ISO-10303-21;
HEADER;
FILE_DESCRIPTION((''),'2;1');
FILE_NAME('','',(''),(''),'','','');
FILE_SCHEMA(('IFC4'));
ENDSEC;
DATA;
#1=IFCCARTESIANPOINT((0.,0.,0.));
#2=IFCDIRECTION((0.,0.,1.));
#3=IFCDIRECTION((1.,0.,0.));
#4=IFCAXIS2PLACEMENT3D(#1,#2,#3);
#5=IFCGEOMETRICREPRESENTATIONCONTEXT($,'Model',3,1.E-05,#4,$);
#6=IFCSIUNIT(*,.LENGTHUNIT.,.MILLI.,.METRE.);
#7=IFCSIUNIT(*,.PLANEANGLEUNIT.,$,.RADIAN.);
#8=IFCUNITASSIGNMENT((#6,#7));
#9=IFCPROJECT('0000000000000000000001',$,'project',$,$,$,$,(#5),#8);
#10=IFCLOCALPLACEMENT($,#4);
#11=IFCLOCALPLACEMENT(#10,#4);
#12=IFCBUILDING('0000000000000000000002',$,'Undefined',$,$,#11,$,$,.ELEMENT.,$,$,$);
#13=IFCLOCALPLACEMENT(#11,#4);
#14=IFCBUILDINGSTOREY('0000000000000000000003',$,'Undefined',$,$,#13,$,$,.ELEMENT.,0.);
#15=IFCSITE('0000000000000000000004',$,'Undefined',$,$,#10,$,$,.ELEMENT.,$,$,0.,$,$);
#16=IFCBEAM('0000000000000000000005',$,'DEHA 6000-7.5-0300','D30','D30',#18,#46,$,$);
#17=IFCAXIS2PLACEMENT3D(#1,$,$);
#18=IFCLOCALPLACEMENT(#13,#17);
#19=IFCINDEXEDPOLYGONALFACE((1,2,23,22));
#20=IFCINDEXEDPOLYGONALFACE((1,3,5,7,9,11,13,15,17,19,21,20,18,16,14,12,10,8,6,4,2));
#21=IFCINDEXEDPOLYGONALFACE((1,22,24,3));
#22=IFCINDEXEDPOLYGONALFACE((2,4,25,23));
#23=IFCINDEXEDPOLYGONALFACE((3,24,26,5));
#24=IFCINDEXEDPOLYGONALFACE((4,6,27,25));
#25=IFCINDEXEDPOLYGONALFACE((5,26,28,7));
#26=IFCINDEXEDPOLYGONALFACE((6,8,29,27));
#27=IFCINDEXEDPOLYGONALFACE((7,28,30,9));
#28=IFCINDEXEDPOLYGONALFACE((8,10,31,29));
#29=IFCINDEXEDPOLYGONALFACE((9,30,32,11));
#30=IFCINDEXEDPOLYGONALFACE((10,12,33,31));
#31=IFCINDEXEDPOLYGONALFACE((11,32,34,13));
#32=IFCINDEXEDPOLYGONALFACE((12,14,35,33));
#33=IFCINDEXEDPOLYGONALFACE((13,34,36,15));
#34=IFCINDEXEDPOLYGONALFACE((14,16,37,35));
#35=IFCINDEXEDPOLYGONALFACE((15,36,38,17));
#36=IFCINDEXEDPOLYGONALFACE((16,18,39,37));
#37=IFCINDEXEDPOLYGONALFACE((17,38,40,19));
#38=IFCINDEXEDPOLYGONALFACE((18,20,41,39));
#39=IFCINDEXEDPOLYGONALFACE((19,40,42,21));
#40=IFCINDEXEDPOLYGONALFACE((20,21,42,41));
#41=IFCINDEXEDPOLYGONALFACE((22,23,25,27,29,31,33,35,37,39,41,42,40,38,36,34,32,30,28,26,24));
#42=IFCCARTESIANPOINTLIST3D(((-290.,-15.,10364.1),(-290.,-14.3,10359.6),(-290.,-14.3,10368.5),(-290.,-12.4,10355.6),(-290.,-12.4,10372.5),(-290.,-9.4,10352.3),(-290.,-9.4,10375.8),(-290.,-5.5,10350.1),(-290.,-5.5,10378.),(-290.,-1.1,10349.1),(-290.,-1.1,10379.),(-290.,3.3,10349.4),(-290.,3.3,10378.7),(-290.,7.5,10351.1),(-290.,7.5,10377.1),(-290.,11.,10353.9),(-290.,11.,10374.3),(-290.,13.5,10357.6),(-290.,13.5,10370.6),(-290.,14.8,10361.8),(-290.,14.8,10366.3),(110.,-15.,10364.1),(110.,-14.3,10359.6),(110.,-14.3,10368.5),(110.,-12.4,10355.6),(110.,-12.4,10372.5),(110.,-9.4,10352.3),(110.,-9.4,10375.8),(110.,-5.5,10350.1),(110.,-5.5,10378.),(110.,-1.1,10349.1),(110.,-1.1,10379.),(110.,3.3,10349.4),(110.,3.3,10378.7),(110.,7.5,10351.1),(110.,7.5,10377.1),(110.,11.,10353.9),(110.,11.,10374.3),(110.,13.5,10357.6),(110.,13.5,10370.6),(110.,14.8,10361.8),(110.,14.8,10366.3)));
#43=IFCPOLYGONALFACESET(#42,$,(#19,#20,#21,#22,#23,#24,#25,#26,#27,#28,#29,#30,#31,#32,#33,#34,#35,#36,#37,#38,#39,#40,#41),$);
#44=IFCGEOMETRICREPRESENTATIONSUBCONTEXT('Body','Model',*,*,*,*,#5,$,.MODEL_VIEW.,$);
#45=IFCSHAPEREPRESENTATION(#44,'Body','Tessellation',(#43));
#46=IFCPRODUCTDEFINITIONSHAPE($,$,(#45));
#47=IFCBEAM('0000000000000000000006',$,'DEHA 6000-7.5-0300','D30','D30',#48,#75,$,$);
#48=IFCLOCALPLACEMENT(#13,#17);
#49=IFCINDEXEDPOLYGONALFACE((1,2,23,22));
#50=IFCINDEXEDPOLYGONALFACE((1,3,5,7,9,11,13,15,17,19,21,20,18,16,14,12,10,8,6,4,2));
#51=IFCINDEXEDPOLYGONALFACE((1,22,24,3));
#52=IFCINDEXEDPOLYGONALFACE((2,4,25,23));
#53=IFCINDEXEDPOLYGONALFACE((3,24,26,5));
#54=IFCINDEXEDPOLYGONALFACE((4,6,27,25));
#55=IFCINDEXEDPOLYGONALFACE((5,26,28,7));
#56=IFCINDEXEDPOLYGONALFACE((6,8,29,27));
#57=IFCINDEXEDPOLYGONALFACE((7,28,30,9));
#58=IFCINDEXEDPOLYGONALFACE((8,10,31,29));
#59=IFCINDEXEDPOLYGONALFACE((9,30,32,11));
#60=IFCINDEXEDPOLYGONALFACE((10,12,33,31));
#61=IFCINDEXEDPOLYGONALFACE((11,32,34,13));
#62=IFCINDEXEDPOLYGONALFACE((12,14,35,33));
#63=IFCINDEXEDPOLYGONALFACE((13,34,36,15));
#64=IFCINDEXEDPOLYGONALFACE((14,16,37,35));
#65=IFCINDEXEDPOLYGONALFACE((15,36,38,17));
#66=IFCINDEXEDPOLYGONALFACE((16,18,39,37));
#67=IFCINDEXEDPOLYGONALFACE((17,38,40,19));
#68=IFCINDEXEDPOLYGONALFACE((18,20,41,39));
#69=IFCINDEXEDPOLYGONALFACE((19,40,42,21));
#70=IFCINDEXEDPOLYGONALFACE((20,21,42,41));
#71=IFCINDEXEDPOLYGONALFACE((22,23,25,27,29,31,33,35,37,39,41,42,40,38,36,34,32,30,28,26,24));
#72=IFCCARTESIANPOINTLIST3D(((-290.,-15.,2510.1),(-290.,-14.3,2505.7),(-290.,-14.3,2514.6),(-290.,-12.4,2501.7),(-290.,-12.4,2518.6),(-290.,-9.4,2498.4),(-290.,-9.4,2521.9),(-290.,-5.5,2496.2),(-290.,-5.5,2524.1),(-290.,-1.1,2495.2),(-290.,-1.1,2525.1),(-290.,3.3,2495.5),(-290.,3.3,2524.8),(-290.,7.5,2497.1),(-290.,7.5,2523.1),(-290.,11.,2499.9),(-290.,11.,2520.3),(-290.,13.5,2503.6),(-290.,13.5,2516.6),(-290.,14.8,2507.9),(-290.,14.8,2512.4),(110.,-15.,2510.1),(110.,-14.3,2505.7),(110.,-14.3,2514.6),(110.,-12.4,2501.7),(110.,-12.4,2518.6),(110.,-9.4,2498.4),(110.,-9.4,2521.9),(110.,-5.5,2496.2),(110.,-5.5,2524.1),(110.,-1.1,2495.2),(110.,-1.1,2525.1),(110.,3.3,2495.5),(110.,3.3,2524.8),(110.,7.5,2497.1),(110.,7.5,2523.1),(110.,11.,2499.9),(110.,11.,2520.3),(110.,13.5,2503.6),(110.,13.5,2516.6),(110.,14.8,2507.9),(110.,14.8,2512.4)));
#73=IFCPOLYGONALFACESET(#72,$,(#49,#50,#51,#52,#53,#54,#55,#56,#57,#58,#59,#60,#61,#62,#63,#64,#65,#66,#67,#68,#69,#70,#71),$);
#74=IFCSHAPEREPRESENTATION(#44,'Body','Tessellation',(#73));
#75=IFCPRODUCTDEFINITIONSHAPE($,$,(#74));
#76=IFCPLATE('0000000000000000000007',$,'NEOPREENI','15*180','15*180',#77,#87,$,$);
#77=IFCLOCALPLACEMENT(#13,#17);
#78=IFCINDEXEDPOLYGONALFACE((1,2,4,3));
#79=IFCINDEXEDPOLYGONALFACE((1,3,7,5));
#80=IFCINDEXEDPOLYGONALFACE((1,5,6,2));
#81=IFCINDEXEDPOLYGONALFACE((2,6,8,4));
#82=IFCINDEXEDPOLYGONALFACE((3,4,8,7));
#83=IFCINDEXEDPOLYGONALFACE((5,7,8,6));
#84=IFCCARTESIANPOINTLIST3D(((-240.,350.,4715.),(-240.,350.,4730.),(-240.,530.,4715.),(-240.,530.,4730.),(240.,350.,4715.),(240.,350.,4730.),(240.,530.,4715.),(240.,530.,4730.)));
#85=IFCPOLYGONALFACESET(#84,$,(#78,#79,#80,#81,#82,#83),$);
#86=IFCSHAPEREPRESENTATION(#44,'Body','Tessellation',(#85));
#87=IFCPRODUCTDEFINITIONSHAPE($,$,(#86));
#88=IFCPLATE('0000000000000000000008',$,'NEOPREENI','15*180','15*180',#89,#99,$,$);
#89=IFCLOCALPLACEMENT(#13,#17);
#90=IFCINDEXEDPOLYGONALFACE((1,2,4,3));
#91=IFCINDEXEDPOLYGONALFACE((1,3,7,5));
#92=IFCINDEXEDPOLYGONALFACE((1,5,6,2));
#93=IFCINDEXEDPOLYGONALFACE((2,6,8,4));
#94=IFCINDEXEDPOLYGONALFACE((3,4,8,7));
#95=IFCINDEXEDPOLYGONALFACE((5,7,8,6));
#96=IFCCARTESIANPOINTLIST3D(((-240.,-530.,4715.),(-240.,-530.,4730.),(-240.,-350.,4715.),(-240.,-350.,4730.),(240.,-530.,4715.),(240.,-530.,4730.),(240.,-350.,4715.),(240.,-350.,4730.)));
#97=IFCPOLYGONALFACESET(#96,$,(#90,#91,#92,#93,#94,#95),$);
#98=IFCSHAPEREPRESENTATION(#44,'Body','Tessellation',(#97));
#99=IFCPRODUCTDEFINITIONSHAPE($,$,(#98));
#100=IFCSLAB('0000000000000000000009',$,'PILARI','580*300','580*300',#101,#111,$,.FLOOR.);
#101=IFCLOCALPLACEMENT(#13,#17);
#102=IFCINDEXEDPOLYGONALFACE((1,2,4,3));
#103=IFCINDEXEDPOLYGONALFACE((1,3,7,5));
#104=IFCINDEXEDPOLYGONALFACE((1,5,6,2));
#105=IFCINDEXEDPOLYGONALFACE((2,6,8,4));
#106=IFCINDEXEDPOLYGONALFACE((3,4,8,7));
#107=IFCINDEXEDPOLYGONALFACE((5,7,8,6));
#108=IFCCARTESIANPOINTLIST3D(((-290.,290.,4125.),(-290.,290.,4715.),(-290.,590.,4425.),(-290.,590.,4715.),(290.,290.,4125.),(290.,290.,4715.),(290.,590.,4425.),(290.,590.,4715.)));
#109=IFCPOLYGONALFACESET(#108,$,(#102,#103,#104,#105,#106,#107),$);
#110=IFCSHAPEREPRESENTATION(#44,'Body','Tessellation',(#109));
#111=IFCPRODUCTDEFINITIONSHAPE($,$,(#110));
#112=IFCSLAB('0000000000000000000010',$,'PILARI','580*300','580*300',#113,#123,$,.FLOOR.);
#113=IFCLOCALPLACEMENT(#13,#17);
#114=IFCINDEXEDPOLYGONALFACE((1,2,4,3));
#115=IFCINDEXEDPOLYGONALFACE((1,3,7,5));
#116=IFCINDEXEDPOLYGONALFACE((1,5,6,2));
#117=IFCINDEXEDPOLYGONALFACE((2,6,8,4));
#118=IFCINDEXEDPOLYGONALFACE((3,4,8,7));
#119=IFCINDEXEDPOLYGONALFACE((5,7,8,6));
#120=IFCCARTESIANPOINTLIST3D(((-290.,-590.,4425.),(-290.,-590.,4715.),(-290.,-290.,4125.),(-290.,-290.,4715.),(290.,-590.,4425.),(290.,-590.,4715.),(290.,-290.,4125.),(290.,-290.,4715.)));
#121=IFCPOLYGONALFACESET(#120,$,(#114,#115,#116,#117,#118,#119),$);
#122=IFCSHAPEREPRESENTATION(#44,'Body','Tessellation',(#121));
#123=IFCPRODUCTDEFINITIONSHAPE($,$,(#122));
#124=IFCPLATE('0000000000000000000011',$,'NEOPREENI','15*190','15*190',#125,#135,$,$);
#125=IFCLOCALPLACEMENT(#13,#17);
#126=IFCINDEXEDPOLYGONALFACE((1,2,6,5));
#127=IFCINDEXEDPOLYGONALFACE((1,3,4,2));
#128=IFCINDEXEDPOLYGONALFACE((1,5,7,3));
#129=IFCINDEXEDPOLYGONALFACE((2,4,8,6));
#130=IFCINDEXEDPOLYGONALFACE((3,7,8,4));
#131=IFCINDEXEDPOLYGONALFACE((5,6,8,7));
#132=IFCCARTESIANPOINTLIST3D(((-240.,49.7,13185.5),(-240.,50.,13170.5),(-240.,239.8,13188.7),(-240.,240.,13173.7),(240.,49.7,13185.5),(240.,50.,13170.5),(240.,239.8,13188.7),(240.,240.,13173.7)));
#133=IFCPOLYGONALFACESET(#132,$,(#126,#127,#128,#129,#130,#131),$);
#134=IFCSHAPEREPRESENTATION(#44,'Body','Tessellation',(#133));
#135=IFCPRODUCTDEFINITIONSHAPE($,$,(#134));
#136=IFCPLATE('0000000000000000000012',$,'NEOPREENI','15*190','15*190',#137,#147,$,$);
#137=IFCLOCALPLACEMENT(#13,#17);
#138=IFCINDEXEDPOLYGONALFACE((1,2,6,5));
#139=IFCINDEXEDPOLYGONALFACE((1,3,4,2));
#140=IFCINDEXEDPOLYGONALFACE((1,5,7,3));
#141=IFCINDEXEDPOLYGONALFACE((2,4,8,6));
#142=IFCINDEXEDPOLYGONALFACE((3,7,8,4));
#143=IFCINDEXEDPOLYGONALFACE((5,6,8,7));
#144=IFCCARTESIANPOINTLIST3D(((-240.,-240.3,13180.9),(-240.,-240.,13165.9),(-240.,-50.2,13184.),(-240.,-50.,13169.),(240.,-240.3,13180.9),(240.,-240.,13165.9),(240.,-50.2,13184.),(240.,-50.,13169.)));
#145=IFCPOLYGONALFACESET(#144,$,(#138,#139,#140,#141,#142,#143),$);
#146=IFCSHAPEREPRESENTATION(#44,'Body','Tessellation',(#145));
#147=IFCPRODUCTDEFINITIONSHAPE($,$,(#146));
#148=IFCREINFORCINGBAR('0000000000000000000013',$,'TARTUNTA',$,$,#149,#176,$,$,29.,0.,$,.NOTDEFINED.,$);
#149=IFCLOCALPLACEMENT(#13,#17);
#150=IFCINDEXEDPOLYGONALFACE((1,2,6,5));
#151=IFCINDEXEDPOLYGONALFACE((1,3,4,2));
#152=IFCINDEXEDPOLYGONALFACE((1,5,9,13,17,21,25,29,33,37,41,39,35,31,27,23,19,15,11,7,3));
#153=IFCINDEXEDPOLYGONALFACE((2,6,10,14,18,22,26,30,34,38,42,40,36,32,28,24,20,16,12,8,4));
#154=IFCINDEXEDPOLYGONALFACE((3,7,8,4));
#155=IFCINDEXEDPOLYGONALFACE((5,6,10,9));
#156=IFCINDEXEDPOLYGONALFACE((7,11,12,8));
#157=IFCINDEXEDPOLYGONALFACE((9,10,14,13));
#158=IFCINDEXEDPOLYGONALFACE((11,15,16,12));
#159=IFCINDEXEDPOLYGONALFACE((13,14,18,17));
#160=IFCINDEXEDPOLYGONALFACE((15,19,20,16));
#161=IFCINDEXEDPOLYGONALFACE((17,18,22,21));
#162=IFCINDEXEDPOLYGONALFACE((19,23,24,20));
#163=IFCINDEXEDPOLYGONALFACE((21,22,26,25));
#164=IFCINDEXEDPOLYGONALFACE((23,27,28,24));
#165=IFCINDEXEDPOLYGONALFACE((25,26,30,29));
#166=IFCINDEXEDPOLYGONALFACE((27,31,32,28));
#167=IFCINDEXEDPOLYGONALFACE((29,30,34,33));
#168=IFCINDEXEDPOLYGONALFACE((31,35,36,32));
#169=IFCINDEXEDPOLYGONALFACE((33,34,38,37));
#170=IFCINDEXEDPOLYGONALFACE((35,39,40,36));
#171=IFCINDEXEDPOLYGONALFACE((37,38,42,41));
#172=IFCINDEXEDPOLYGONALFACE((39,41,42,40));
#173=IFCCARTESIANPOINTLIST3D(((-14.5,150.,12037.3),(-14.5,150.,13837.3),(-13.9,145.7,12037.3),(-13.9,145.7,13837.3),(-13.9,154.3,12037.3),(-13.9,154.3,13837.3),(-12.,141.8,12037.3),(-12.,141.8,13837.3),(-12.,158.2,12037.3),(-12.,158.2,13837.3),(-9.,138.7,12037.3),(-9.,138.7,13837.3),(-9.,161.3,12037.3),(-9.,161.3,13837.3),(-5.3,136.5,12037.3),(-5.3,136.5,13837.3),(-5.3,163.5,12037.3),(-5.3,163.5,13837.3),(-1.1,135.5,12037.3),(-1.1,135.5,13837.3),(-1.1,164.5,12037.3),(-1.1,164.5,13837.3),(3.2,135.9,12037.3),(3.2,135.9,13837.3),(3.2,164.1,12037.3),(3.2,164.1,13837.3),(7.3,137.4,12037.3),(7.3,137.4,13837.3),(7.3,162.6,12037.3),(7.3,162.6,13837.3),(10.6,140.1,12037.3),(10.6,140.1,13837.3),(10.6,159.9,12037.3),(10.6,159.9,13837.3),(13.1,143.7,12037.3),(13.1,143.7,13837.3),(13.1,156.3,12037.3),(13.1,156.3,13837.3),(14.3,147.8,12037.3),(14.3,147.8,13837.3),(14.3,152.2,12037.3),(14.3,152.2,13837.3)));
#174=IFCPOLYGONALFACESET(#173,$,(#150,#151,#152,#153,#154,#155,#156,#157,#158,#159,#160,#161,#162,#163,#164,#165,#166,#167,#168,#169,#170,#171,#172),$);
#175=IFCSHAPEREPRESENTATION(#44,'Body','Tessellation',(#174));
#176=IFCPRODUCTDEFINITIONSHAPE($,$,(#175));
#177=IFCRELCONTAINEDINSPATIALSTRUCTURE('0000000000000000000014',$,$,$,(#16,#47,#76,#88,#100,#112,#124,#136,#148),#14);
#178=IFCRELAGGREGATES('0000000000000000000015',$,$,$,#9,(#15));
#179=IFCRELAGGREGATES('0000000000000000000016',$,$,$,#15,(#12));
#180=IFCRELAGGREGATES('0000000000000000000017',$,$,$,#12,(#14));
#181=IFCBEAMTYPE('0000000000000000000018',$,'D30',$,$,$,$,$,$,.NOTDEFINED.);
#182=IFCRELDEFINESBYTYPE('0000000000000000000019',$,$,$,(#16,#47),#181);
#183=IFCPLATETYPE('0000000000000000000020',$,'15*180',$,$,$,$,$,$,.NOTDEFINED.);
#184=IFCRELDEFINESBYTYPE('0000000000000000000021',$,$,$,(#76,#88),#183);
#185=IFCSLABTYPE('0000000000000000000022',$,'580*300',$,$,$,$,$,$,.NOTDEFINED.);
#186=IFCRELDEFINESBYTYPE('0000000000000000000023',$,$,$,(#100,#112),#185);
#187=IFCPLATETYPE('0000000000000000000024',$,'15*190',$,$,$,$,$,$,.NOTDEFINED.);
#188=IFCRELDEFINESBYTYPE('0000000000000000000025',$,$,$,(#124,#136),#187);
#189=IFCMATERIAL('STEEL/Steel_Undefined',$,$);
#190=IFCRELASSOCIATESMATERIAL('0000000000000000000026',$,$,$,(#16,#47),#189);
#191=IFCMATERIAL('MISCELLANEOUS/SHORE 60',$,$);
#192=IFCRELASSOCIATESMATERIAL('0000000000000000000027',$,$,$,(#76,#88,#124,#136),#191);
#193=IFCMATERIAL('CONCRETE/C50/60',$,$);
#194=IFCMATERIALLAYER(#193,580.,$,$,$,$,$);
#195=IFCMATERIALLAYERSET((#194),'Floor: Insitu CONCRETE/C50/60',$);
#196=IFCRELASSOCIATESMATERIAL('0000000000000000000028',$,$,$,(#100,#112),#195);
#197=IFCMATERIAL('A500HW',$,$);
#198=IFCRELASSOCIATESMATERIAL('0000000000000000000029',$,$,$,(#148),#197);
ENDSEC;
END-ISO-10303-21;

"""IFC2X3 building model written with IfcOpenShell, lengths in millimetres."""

from ifc_helpers import new_model, entity, si_unit, frame, origin_with_axes, origin_2d_with_axis, place, context, subcontext, project, spatial, polyline, circle, outline, extrude, source, transform, mapped, material, layer, layer_set, layer_usage, type_object, element, save


model = new_model("IFC2X3")

# Units and contexts
model_context = context("Model", 3, precision=1e-05, world=origin_with_axes())
body_context = subcontext(model_context, "Body", "Model", "MODEL_VIEW")
ifc_project = project(units=[si_unit("LENGTHUNIT", "METRE", prefix="MILLI"), si_unit("PLANEANGLEUNIT", "RADIAN")], contexts=[model_context])

# Site, building, storey
site_placement = place(None, origin_with_axes())
site = spatial("IfcSite", under=ifc_project, at=site_placement, Name="Undefined", CompositionType="ELEMENT", RefElevation=0.0)
building_placement = place(site_placement, origin_with_axes())
building = spatial("IfcBuilding", under=site, at=building_placement, Name="Undefined", CompositionType="ELEMENT")
storey_placement = place(building_placement, origin_with_axes())
storey = spatial("IfcBuildingStorey", under=building, at=storey_placement, Name="Undefined", CompositionType="ELEMENT", Elevation=0.0)

# Beams
ifc_material_1 = material(Name="STEEL/Steel_Undefined")
beam_type_1 = type_object("IfcBeamType", Name="D30", PredefinedType="NOTDEFINED")
for number, where, z_axis, x_axis, name in (
    (1, (-290.0, 0.0, 10364.1), (0.0, 0.0, 1.0), (1.0, 0.0, 0.0), "DEHA 6000-7.5-0300"),
    (2, (-290.0, 0.0, 2510.1), (0.0, 0.0, 1.0), (1.0, 0.0, 0.0), "DEHA 6000-7.5-0300"),
):
    element("IfcBeam", number, at=place(storey_placement, frame(where, z_axis=z_axis, x_axis=x_axis)), inside=storey, type_object=beam_type_1, material=ifc_material_1, Name=name, Description="D30", ObjectType="D30", context=body_context, shape_type="SweptSolid", body=[
        extrude(circle(Radius=15.0, at=origin_2d_with_axis()), frame((400.0, 0.0, 0.0), z_axis=(-1.0, 0.0, 0.0), x_axis=(0.0, -1.0, 0.0)), (0.0, 0.0, 1.0), 400.0),
    ])

# Plates
ifc_material_2 = material(Name="MISCELLANEOUS/SHORE 60")
plate_type_1 = type_object("IfcPlateType", Name="15*180", PredefinedType="NOTDEFINED")
for number, where, z_axis, x_axis, name in (
    (3, (-240.0, 530.0, 4722.5), (0.0, 0.0, 1.0), (0.0, -1.0, 0.0), "NEOPREENI"),
    (4, (240.0, -530.0, 4722.5), (0.0, 0.0, 1.0), (0.0, 1.0, 0.0), "NEOPREENI"),
):
    element("IfcPlate", number, at=place(storey_placement, frame(where, z_axis=z_axis, x_axis=x_axis)), inside=storey, type_object=plate_type_1, material=ifc_material_2, Name=name, Description="15*180", ObjectType="15*180", context=body_context, shape_type="SweptSolid", body=[
        extrude(outline(polyline([(0.0, 0.0), (180.0, 0.0), (180.0, 480.0), (0.0, 480.0), (0.0, 0.0)])), frame((0.0, 0.0, -7.5), z_axis=(0.0, 0.0, 1.0), x_axis=(1.0, 0.0, 0.0)), (0.0, 0.0, 1.0), 15.0),
    ])

# Slabs
ifc_material_3 = material(Name="CONCRETE/C50/60")
ifc_layer = layer(ifc_material_3, 580.0)
ifc_layer_set = layer_set([ifc_layer], Name="Floor: Insitu CONCRETE/C50/60")
ifc_layer_usage_1 = layer_usage(ifc_layer_set, "AXIS3", "POSITIVE", -290.0)
slab_type = type_object("IfcSlabType", Name="580*300", PredefinedType="NOTDEFINED")
slab_1_placement = place(storey_placement, frame((0.0, 290.0, 4125.0), z_axis=(1.0, 0.0, 0.0), x_axis=(0.0, 0.707107, 0.707107)))
element("IfcSlab", 5, at=slab_1_placement, inside=storey, type_object=slab_type, material=ifc_layer_usage_1, Name="PILARI", Description="580*300", ObjectType="580*300", PredefinedType="FLOOR", context=body_context, shape_type="SweptSolid", body=[
    extrude(outline(polyline([(0.0, 0.0), (424.3, 0.0), (629.3, 205.1), (417.2, 417.2), (0.0, 0.0)])), frame((0.0, 0.0, -290.0), z_axis=(0.0, 0.0, 1.0), x_axis=(1.0, 0.0, 0.0)), (0.0, 0.0, 1.0), 580.0),
])
ifc_layer_usage_2 = layer_usage(ifc_layer_set, "AXIS3", "POSITIVE", -290.0)
slab_2_placement = place(storey_placement, frame((0.0, -290.0, 4125.0), z_axis=(-1.0, 0.0, 0.0), x_axis=(0.0, -0.707107, 0.707107)))
element("IfcSlab", 6, at=slab_2_placement, inside=storey, type_object=slab_type, material=ifc_layer_usage_2, Name="PILARI", Description="580*300", ObjectType="580*300", PredefinedType="FLOOR", context=body_context, shape_type="SweptSolid", body=[
    extrude(outline(polyline([(0.0, 0.0), (424.3, 0.0), (629.3, 205.1), (417.2, 417.2), (0.0, 0.0)])), frame((0.0, 0.0, -290.0), z_axis=(0.0, 0.0, 1.0), x_axis=(1.0, 0.0, 0.0)), (0.0, 0.0, 1.0), 580.0),
])

# Plates
plate_type_2 = type_object("IfcPlateType", Name="15*190", PredefinedType="NOTDEFINED")
for number, where, z_axis, x_axis, name in (
    (7, (-240.0, 49.9, 13178.0), (0.0, -0.016586, 0.999862), (1.0, 0.0, 0.0), "NEOPREENI"),
    (8, (-240.0, -240.1, 13173.4), (0.0, -0.016586, 0.999862), (1.0, 0.0, 0.0), "NEOPREENI"),
):
    element("IfcPlate", number, at=place(storey_placement, frame(where, z_axis=z_axis, x_axis=x_axis)), inside=storey, type_object=plate_type_2, material=ifc_material_2, Name=name, Description="15*190", ObjectType="15*190", context=body_context, shape_type="SweptSolid", body=[
        extrude(outline(polyline([(0.0, 0.0), (480.0, 0.0), (480.0, 190.0), (0.0, 190.0), (0.0, 0.0)])), frame((0.0, 0.0, -7.5), z_axis=(0.0, 0.0, 1.0), x_axis=(1.0, 0.0, 0.0)), (0.0, 0.0, 1.0), 15.0),
    ])

# Reinforcing bar
ifc_material_4 = material(Name="A500HW")
shared_shape_1 = source(origin_with_axes(), body_context, "Body", "AdvancedSweptSolid", [
    entity("IfcSweptDiskSolid", entity("IfcTrimmedCurve", entity("IfcLine", entity("IfcCartesianPoint", [0.0, 0.0, 0.0]), entity("IfcVector", entity("IfcDirection", [1.0, 0.0, 0.0]), 1.0)), [entity("IfcParameterValue", 0.0)], [entity("IfcParameterValue", 1799.999454)], True, "PARAMETER"), 14.5, None, 0.0, 1800.0),
])
reinforcing_bar_1_placement = place(storey_placement, frame((0.0, 150.0, 13837.3), z_axis=(-1.0, 0.0, 0.0), x_axis=(0.0, 0.0, -1.0)))
element("IfcReinforcingBar", 9, at=reinforcing_bar_1_placement, inside=storey, material=ifc_material_4, Name="TARTUNTA", BarRole="NOTDEFINED", CrossSectionArea=0.0, NominalDiameter=29.0, context=body_context, shape_type="MappedRepresentation", body=[
    mapped(shared_shape_1, transform((0.0, 0.0, 0.0))),
])

save(model, "model.ifc")
